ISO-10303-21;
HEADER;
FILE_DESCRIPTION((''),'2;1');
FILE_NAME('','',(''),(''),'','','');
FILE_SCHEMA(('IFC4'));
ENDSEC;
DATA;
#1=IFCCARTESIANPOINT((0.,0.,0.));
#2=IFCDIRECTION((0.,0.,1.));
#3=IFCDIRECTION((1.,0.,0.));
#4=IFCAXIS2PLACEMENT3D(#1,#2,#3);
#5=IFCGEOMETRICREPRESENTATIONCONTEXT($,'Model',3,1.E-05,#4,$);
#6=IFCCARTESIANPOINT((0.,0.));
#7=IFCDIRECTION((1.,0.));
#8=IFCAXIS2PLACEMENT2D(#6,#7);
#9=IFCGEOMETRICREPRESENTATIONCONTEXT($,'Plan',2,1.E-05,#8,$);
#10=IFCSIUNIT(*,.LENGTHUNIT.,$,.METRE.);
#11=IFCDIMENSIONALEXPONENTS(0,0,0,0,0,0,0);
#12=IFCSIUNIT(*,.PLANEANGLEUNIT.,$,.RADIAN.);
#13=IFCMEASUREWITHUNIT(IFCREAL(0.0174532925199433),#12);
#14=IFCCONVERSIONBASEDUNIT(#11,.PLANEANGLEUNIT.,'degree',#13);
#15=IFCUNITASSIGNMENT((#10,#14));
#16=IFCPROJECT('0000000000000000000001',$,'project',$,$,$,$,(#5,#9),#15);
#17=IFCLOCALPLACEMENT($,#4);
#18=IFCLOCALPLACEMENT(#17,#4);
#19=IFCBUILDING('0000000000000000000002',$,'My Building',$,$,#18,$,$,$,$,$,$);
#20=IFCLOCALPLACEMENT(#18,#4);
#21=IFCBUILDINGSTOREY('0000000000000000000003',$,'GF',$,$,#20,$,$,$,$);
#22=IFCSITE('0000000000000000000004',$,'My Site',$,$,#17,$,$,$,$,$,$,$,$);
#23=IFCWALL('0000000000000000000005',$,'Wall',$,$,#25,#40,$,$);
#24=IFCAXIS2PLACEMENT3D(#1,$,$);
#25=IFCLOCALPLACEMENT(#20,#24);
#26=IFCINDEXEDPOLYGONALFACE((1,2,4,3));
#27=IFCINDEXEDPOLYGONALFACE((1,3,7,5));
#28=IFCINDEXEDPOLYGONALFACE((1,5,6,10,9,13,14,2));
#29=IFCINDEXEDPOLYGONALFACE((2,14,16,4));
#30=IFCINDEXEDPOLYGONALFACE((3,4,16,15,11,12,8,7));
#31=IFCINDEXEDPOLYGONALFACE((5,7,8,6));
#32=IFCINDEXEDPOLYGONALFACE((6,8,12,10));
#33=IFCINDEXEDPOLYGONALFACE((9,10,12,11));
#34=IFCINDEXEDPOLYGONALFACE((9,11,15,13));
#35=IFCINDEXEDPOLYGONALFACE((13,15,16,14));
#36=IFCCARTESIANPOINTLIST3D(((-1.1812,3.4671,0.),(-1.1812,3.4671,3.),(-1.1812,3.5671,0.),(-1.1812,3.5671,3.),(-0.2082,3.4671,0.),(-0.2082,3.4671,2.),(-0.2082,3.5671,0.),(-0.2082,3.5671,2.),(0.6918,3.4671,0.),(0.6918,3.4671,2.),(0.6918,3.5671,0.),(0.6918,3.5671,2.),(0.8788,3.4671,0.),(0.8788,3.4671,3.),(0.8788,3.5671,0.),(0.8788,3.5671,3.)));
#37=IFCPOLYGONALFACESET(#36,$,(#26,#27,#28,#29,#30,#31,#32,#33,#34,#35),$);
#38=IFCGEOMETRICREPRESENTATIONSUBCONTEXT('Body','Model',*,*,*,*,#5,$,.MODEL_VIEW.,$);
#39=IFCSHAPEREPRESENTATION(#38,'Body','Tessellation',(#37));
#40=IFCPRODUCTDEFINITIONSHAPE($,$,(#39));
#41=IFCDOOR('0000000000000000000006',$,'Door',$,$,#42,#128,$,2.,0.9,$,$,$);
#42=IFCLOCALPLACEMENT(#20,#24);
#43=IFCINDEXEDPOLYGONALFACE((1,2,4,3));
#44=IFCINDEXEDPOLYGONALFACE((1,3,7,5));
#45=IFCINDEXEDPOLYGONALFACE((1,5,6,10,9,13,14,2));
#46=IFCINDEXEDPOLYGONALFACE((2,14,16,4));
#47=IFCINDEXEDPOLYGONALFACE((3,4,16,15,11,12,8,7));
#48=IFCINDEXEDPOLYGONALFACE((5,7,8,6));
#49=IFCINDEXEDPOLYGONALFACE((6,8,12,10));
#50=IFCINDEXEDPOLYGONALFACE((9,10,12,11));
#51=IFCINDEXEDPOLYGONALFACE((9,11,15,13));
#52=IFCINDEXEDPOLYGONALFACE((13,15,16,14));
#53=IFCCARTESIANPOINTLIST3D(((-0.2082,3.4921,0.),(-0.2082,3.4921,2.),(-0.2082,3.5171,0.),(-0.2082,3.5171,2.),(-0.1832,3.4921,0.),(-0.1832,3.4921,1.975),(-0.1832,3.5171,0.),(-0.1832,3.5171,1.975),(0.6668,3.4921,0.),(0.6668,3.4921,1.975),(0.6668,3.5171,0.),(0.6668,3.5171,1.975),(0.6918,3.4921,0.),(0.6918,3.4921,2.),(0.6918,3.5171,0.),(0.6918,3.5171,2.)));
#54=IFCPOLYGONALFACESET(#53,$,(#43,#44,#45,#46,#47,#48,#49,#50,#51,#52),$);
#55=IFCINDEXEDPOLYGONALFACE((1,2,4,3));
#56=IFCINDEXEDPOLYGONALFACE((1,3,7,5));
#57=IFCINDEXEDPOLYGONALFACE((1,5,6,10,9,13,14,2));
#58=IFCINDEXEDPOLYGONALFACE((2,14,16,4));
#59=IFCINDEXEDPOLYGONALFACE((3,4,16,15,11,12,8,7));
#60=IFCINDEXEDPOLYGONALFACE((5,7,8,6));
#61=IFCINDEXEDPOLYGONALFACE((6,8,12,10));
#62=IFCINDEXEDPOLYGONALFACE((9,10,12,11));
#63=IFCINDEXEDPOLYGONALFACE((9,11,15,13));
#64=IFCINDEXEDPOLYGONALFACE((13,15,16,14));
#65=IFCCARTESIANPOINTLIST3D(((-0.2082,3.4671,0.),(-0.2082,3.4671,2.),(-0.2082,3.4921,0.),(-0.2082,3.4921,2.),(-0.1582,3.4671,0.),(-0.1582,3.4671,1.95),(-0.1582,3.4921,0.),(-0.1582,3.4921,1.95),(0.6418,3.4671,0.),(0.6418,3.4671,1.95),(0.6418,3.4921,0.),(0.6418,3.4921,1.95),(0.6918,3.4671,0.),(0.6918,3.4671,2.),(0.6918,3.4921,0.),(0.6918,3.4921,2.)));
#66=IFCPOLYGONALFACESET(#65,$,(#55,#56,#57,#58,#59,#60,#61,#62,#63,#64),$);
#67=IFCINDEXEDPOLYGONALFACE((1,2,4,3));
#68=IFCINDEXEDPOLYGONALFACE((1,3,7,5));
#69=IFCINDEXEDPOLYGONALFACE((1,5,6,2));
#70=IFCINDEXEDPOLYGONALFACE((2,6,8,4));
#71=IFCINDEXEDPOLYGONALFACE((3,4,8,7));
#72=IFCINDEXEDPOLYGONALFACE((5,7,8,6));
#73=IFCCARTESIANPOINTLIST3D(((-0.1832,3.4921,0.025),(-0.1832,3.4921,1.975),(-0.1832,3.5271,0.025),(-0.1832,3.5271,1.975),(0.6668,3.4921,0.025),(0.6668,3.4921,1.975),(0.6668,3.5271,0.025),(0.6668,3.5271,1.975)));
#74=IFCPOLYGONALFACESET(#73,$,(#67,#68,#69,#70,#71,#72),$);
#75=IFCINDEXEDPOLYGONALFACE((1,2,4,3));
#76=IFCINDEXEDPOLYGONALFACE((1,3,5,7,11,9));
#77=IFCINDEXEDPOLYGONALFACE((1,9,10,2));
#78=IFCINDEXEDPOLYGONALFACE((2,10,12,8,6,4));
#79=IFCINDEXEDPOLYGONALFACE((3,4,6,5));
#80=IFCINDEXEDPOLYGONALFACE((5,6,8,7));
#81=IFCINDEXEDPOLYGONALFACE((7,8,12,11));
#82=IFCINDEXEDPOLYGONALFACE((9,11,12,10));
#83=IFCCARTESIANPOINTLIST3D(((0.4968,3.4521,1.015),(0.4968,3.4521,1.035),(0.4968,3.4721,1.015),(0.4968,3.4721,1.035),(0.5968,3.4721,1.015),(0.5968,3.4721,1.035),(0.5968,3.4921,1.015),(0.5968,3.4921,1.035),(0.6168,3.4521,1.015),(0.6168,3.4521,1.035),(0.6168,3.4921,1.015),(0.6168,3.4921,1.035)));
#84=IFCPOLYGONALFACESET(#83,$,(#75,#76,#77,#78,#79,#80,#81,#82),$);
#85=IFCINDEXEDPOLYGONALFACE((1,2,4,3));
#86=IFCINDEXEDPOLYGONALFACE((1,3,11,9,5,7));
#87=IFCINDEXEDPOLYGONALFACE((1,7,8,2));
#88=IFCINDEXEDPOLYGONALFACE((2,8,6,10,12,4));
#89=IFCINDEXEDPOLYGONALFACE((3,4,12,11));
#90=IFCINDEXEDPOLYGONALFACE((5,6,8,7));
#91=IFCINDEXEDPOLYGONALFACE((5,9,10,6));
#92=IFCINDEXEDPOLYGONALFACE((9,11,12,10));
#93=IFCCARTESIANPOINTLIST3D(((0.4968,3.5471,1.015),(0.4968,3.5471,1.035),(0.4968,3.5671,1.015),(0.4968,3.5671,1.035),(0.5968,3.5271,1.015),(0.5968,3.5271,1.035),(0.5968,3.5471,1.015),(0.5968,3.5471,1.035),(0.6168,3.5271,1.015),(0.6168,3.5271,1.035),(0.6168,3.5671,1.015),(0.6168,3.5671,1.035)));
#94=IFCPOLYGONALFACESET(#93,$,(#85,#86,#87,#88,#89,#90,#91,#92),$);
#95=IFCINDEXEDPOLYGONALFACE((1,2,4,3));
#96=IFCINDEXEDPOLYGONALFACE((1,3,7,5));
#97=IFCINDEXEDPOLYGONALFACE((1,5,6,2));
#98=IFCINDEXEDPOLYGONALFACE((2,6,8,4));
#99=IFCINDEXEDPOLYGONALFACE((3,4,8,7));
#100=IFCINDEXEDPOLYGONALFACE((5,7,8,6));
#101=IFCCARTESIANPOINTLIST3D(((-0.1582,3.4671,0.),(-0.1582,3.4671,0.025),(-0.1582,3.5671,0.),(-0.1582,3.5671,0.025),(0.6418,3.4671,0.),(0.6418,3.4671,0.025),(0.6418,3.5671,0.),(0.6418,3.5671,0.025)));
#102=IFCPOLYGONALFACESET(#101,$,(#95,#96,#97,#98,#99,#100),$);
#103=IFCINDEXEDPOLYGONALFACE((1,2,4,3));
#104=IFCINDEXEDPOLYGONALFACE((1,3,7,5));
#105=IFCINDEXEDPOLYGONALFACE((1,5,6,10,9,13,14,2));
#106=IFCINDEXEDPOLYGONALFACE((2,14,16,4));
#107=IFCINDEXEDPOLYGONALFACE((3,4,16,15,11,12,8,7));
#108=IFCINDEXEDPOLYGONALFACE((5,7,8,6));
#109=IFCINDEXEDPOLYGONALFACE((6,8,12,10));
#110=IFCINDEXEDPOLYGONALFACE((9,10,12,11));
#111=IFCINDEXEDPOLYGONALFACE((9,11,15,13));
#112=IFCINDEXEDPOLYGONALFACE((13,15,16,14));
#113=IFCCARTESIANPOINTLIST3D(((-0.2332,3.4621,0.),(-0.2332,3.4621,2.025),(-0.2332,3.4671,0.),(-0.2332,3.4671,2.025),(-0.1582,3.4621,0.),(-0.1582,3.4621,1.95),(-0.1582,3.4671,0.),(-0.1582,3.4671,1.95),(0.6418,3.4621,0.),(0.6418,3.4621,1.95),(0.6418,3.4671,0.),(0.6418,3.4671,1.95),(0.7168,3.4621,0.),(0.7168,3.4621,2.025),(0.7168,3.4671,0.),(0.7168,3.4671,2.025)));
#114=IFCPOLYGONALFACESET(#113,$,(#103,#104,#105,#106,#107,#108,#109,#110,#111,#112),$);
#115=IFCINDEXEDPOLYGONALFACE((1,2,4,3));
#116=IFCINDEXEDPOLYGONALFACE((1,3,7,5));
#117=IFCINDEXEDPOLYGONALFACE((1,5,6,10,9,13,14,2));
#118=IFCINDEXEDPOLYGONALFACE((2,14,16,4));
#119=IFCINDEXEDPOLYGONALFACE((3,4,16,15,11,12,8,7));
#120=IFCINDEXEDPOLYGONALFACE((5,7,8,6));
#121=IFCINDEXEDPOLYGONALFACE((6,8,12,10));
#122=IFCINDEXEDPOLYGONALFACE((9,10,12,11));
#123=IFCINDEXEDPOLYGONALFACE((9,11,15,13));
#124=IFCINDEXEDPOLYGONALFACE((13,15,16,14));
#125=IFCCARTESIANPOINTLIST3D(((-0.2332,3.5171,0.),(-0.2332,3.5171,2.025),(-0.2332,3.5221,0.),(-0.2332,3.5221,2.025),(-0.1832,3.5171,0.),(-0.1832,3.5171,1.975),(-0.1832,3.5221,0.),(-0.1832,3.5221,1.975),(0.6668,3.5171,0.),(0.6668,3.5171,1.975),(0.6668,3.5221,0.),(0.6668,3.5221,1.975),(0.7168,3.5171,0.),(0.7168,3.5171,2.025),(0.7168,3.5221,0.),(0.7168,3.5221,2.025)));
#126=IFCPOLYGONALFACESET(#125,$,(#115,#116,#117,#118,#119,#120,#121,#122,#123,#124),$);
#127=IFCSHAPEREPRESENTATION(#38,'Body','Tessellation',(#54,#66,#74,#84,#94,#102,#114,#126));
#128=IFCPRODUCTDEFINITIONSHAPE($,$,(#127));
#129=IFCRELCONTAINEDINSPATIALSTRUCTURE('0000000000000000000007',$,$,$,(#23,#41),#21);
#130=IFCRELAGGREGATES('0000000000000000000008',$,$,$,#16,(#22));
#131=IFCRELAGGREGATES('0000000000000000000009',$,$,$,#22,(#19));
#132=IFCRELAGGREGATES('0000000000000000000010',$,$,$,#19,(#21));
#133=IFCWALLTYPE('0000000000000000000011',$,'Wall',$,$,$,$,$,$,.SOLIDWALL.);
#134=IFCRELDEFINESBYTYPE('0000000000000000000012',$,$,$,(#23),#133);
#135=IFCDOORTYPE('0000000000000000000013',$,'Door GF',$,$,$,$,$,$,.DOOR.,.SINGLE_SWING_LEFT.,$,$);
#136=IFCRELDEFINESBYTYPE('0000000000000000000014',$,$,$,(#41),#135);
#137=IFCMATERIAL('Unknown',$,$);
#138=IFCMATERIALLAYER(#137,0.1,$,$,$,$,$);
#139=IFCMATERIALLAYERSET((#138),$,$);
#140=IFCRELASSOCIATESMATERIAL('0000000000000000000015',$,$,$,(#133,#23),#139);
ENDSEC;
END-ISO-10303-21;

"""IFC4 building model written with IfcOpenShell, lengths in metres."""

from ifc_helpers import new_model, entity, si_unit, converted_unit, frame, origin_with_axes, origin_2d_with_axis, place, context, subcontext, project, spatial, line, indexed_curve, outline, extrude, shape, source, transform, mapped, material, layer, layer_set, layer_usage, type_object, type_shapes, element, fill, save


model = new_model("IFC4")

# Units and contexts
model_context = context("Model", 3, precision=1e-05, world=origin_with_axes())
plan_context = context("Plan", 2, precision=1e-05, world=origin_2d_with_axis())
body_context_1 = subcontext(model_context, "Body", "Model", "MODEL_VIEW")
body_context_2 = subcontext(plan_context, "Body", "Plan", "PLAN_VIEW")
ifc_project = project(units=[si_unit("LENGTHUNIT", "METRE"), converted_unit("PLANEANGLEUNIT", "degree", entity("IfcReal", 0.0174532925199433), si_unit("PLANEANGLEUNIT", "RADIAN"), dimensions=[0, 0, 0, 0, 0, 0, 0])], contexts=[model_context, plan_context])

# Site, building, storey
site_placement = place(None, origin_with_axes())
site = spatial("IfcSite", under=ifc_project, at=site_placement, Name="My Site")
building_placement = place(site_placement, origin_with_axes())
building = spatial("IfcBuilding", under=site, at=building_placement, Name="My Building")
storey_placement = place(building_placement, origin_with_axes())
storey = spatial("IfcBuildingStorey", under=building, at=storey_placement, Name="GF")

# Shared definitions
ifc_material = material(Name="Unknown")

# Shared definitions
ifc_layer_1 = layer(ifc_material, 0.1)
ifc_layer_set_1 = layer_set([ifc_layer_1])
wall_type = type_object("IfcWallType", Name="Wall", PredefinedType="SOLIDWALL", material=ifc_layer_set_1)
shared_shape_1 = source(origin_with_axes(), body_context_1, "Body", "SweptSolid", [
    extrude(outline(indexed_curve([(0.0, 0.0), (0.9, 0.0), (0.9, 2.0), (0.0, 2.0)], segments=[line(1, 2, 3, 4, 1)])), frame((0.0, -0.6, 0.0), z_axis=(0.0, -1.0, 0.0), x_axis=(1.0, 0.0, 0.0)), (0.0, 0.0, -1.0), 1.2),
])
door_type = type_object("IfcDoorType", Name="Door GF", OperationType="SINGLE_SWING_LEFT", PredefinedType="DOOR")
shared_shape_2 = source(origin_with_axes(), body_context_1, "Body", "SweptSolid", [
    extrude(outline(indexed_curve([(0.0, 0.0), (0.0, 2.0), (0.9, 2.0), (0.9, 0.0), (0.875, 0.0), (0.875, 1.975), (0.025, 1.975), (0.025, 0.0)], segments=[line(1, 2, 3, 4, 5, 6, 7, 8, 1)])), frame((0.0, 0.025, 0.0), z_axis=(0.0, -1.0, 0.0), x_axis=(1.0, 0.0, 0.0)), (0.0, 0.0, -1.0), 0.025),
    extrude(outline(indexed_curve([(0.0, 0.0), (0.0, 2.0), (0.9, 2.0), (0.9, 0.0), (0.85, 0.0), (0.85, 1.95), (0.05, 1.95), (0.05, 0.0)], segments=[line(1, 2, 3, 4, 5, 6, 7, 8, 1)])), frame((0.0, 0.0, 0.0), z_axis=(0.0, -1.0, 0.0), x_axis=(1.0, 0.0, 0.0)), (0.0, 0.0, -1.0), 0.025),
    extrude(outline(indexed_curve([(0.0, 0.0), (0.85, 0.0), (0.85, 0.035), (0.0, 0.035)], segments=[line(1, 2, 3, 4, 1)])), frame((0.025, 0.025, 0.025), z_axis=(0.0, 0.0, 1.0), x_axis=(1.0, 0.0, 0.0)), (0.0, 0.0, 1.0), 1.95),
    extrude(outline(indexed_curve([(0.0, 0.0), (0.0, -0.04), (-0.12, -0.04), (-0.12, -0.02), (-0.02, -0.02), (-0.02, 0.0)], segments=[line(1, 2, 3, 4, 5, 6, 1)])), frame((0.825, 0.025, 1.015), z_axis=(0.0, 0.0, 1.0), x_axis=(1.0, 0.0, 0.0)), (0.0, 0.0, 1.0), 0.02),
    extrude(outline(indexed_curve([(0.0, 0.0), (0.0, 0.04), (-0.12, 0.04), (-0.12, 0.02), (-0.02, 0.02), (-0.02, 0.0)], segments=[line(1, 2, 3, 4, 5, 6, 1)])), frame((0.825, 0.06, 1.015), z_axis=(0.0, 0.0, 1.0), x_axis=(1.0, 0.0, 0.0)), (0.0, 0.0, 1.0), 0.02),
    extrude(outline(indexed_curve([(0.0, 0.0), (0.8, 0.0), (0.8, 0.1), (0.0, 0.1)], segments=[line(1, 2, 3, 4, 1)])), frame((0.05, 0.0, 0.0), z_axis=(0.0, 0.0, 1.0), x_axis=(1.0, 0.0, 0.0)), (0.0, 0.0, 1.0), 0.025),
    extrude(outline(indexed_curve([(0.0, 0.0), (0.0, 2.025), (0.95, 2.025), (0.95, 0.0), (0.875, 0.0), (0.875, 1.95), (0.075, 1.95), (0.075, 0.0)], segments=[line(1, 2, 3, 4, 5, 6, 7, 8, 1)])), frame((-0.025, -0.005, 0.0), z_axis=(0.0, -1.0, 0.0), x_axis=(1.0, 0.0, 0.0)), (0.0, 0.0, -1.0), 0.005),
    extrude(outline(indexed_curve([(0.0, 0.0), (0.0, 2.025), (0.95, 2.025), (0.95, 0.0), (0.9, 0.0), (0.9, 1.975), (0.05, 1.975), (0.05, 0.0)], segments=[line(1, 2, 3, 4, 5, 6, 7, 8, 1)])), frame((-0.025, 0.05, 0.0), z_axis=(0.0, -1.0, 0.0), x_axis=(1.0, 0.0, 0.0)), (0.0, 0.0, -1.0), 0.005),
])
shared_shape_3 = source(origin_with_axes(), body_context_2, "Body", "Curve2D", [
    entity("IfcIndexedPolyCurve", entity("IfcCartesianPointList2D", [[0.0, 0.0], [0.0, 0.05], [0.025, 0.05], [0.025, 0.025], [0.05, 0.025], [0.05, 0.0]]), [entity("IfcLineIndex", [1, 2, 3, 4, 5, 6, 1])]),
    entity("IfcIndexedPolyCurve", entity("IfcCartesianPointList2D", [[0.9, 0.0], [0.9, 0.05], [0.875, 0.05], [0.875, 0.025], [0.85, 0.025], [0.85, 0.0]]), [entity("IfcLineIndex", [1, 2, 3, 4, 5, 6, 1])]),
    entity("IfcTrimmedCurve", entity("IfcEllipse", entity("IfcAxis2Placement2D", entity("IfcCartesianPoint", [0.06, 0.05]), entity("IfcDirection", [1.0, 0.0])), 0.815, 0.85), [entity("IfcCartesianPoint", [0.875, 0.05])], [entity("IfcCartesianPoint", [0.06, 0.9])], True, "CARTESIAN"),
    entity("IfcIndexedPolyCurve", entity("IfcCartesianPointList2D", [[0.025, 0.05], [0.06, 0.05], [0.06, 0.9], [0.025, 0.9]]), [entity("IfcLineIndex", [1, 2, 3, 4, 1])]),
])
type_shapes(door_type, [shared_shape_2, shared_shape_3])

# Wall, opening, door
ifc_layer_usage_1 = layer_usage(ifc_layer_set_1, "AXIS2", "POSITIVE", 0.0)
wall_1_placement = place(storey_placement, frame((-1.1812, 3.4671, 0.0), z_axis=(0.0, 0.0, 1.0), x_axis=(1.0, 0.0, 0.0)))
wall_1 = element("IfcWall", 1, at=wall_1_placement, inside=storey, type_object=wall_type, material=ifc_layer_usage_1, Name="Wall", context=body_context_1, shape_type="SweptSolid", body=[
    extrude(outline(indexed_curve([(0.0, 0.0), (0.0, 0.1), (2.06, 0.1), (2.06, 0.0)], segments=[line(1, 2, 3, 4, 1)])), origin_with_axes(), (0.0, 0.0, 1.0), 3.0),
])
opening_1_placement = place(wall_1_placement, frame((0.973, 0.0, 0.0), z_axis=(0.0, 0.0, 1.0), x_axis=(1.0, 0.0, 0.0)))
opening_1 = element("IfcOpeningElement", 2, at=opening_1_placement, cuts=wall_1, PredefinedType="OPENING", context=body_context_1, shape_type="MappedRepresentation", body=[
    mapped(shared_shape_1, transform((0.0, 0.0, 0.0), x_axis=(1.0, 0.0, 0.0), y_axis=(0.0, 1.0, 0.0), z_axis=(0.0, 0.0, 1.0), scale=1.0)),
])
door_1_placement = place(opening_1_placement, origin_with_axes())
door_1 = element("IfcDoor", 3, at=door_1_placement, inside=storey, type_object=door_type, Name="Door", OverallHeight=2.0, OverallWidth=0.9, shapes=[
    shape(body_context_1, "Body", "MappedRepresentation", [mapped(shared_shape_2, transform((0.0, 0.0, 0.0), x_axis=(1.0, 0.0, 0.0), y_axis=(0.0, 1.0, 0.0), z_axis=(0.0, 0.0, 1.0), scale=1.0))]),
    shape(body_context_2, "Body", "MappedRepresentation", [mapped(shared_shape_3, transform((0.0, 0.0, 0.0), x_axis=(1.0, 0.0, 0.0), y_axis=(0.0, 1.0, 0.0), z_axis=(0.0, 0.0, 1.0), scale=1.0))]),
])
fill(opening_1, door_1)

save(model, "model.ifc")
